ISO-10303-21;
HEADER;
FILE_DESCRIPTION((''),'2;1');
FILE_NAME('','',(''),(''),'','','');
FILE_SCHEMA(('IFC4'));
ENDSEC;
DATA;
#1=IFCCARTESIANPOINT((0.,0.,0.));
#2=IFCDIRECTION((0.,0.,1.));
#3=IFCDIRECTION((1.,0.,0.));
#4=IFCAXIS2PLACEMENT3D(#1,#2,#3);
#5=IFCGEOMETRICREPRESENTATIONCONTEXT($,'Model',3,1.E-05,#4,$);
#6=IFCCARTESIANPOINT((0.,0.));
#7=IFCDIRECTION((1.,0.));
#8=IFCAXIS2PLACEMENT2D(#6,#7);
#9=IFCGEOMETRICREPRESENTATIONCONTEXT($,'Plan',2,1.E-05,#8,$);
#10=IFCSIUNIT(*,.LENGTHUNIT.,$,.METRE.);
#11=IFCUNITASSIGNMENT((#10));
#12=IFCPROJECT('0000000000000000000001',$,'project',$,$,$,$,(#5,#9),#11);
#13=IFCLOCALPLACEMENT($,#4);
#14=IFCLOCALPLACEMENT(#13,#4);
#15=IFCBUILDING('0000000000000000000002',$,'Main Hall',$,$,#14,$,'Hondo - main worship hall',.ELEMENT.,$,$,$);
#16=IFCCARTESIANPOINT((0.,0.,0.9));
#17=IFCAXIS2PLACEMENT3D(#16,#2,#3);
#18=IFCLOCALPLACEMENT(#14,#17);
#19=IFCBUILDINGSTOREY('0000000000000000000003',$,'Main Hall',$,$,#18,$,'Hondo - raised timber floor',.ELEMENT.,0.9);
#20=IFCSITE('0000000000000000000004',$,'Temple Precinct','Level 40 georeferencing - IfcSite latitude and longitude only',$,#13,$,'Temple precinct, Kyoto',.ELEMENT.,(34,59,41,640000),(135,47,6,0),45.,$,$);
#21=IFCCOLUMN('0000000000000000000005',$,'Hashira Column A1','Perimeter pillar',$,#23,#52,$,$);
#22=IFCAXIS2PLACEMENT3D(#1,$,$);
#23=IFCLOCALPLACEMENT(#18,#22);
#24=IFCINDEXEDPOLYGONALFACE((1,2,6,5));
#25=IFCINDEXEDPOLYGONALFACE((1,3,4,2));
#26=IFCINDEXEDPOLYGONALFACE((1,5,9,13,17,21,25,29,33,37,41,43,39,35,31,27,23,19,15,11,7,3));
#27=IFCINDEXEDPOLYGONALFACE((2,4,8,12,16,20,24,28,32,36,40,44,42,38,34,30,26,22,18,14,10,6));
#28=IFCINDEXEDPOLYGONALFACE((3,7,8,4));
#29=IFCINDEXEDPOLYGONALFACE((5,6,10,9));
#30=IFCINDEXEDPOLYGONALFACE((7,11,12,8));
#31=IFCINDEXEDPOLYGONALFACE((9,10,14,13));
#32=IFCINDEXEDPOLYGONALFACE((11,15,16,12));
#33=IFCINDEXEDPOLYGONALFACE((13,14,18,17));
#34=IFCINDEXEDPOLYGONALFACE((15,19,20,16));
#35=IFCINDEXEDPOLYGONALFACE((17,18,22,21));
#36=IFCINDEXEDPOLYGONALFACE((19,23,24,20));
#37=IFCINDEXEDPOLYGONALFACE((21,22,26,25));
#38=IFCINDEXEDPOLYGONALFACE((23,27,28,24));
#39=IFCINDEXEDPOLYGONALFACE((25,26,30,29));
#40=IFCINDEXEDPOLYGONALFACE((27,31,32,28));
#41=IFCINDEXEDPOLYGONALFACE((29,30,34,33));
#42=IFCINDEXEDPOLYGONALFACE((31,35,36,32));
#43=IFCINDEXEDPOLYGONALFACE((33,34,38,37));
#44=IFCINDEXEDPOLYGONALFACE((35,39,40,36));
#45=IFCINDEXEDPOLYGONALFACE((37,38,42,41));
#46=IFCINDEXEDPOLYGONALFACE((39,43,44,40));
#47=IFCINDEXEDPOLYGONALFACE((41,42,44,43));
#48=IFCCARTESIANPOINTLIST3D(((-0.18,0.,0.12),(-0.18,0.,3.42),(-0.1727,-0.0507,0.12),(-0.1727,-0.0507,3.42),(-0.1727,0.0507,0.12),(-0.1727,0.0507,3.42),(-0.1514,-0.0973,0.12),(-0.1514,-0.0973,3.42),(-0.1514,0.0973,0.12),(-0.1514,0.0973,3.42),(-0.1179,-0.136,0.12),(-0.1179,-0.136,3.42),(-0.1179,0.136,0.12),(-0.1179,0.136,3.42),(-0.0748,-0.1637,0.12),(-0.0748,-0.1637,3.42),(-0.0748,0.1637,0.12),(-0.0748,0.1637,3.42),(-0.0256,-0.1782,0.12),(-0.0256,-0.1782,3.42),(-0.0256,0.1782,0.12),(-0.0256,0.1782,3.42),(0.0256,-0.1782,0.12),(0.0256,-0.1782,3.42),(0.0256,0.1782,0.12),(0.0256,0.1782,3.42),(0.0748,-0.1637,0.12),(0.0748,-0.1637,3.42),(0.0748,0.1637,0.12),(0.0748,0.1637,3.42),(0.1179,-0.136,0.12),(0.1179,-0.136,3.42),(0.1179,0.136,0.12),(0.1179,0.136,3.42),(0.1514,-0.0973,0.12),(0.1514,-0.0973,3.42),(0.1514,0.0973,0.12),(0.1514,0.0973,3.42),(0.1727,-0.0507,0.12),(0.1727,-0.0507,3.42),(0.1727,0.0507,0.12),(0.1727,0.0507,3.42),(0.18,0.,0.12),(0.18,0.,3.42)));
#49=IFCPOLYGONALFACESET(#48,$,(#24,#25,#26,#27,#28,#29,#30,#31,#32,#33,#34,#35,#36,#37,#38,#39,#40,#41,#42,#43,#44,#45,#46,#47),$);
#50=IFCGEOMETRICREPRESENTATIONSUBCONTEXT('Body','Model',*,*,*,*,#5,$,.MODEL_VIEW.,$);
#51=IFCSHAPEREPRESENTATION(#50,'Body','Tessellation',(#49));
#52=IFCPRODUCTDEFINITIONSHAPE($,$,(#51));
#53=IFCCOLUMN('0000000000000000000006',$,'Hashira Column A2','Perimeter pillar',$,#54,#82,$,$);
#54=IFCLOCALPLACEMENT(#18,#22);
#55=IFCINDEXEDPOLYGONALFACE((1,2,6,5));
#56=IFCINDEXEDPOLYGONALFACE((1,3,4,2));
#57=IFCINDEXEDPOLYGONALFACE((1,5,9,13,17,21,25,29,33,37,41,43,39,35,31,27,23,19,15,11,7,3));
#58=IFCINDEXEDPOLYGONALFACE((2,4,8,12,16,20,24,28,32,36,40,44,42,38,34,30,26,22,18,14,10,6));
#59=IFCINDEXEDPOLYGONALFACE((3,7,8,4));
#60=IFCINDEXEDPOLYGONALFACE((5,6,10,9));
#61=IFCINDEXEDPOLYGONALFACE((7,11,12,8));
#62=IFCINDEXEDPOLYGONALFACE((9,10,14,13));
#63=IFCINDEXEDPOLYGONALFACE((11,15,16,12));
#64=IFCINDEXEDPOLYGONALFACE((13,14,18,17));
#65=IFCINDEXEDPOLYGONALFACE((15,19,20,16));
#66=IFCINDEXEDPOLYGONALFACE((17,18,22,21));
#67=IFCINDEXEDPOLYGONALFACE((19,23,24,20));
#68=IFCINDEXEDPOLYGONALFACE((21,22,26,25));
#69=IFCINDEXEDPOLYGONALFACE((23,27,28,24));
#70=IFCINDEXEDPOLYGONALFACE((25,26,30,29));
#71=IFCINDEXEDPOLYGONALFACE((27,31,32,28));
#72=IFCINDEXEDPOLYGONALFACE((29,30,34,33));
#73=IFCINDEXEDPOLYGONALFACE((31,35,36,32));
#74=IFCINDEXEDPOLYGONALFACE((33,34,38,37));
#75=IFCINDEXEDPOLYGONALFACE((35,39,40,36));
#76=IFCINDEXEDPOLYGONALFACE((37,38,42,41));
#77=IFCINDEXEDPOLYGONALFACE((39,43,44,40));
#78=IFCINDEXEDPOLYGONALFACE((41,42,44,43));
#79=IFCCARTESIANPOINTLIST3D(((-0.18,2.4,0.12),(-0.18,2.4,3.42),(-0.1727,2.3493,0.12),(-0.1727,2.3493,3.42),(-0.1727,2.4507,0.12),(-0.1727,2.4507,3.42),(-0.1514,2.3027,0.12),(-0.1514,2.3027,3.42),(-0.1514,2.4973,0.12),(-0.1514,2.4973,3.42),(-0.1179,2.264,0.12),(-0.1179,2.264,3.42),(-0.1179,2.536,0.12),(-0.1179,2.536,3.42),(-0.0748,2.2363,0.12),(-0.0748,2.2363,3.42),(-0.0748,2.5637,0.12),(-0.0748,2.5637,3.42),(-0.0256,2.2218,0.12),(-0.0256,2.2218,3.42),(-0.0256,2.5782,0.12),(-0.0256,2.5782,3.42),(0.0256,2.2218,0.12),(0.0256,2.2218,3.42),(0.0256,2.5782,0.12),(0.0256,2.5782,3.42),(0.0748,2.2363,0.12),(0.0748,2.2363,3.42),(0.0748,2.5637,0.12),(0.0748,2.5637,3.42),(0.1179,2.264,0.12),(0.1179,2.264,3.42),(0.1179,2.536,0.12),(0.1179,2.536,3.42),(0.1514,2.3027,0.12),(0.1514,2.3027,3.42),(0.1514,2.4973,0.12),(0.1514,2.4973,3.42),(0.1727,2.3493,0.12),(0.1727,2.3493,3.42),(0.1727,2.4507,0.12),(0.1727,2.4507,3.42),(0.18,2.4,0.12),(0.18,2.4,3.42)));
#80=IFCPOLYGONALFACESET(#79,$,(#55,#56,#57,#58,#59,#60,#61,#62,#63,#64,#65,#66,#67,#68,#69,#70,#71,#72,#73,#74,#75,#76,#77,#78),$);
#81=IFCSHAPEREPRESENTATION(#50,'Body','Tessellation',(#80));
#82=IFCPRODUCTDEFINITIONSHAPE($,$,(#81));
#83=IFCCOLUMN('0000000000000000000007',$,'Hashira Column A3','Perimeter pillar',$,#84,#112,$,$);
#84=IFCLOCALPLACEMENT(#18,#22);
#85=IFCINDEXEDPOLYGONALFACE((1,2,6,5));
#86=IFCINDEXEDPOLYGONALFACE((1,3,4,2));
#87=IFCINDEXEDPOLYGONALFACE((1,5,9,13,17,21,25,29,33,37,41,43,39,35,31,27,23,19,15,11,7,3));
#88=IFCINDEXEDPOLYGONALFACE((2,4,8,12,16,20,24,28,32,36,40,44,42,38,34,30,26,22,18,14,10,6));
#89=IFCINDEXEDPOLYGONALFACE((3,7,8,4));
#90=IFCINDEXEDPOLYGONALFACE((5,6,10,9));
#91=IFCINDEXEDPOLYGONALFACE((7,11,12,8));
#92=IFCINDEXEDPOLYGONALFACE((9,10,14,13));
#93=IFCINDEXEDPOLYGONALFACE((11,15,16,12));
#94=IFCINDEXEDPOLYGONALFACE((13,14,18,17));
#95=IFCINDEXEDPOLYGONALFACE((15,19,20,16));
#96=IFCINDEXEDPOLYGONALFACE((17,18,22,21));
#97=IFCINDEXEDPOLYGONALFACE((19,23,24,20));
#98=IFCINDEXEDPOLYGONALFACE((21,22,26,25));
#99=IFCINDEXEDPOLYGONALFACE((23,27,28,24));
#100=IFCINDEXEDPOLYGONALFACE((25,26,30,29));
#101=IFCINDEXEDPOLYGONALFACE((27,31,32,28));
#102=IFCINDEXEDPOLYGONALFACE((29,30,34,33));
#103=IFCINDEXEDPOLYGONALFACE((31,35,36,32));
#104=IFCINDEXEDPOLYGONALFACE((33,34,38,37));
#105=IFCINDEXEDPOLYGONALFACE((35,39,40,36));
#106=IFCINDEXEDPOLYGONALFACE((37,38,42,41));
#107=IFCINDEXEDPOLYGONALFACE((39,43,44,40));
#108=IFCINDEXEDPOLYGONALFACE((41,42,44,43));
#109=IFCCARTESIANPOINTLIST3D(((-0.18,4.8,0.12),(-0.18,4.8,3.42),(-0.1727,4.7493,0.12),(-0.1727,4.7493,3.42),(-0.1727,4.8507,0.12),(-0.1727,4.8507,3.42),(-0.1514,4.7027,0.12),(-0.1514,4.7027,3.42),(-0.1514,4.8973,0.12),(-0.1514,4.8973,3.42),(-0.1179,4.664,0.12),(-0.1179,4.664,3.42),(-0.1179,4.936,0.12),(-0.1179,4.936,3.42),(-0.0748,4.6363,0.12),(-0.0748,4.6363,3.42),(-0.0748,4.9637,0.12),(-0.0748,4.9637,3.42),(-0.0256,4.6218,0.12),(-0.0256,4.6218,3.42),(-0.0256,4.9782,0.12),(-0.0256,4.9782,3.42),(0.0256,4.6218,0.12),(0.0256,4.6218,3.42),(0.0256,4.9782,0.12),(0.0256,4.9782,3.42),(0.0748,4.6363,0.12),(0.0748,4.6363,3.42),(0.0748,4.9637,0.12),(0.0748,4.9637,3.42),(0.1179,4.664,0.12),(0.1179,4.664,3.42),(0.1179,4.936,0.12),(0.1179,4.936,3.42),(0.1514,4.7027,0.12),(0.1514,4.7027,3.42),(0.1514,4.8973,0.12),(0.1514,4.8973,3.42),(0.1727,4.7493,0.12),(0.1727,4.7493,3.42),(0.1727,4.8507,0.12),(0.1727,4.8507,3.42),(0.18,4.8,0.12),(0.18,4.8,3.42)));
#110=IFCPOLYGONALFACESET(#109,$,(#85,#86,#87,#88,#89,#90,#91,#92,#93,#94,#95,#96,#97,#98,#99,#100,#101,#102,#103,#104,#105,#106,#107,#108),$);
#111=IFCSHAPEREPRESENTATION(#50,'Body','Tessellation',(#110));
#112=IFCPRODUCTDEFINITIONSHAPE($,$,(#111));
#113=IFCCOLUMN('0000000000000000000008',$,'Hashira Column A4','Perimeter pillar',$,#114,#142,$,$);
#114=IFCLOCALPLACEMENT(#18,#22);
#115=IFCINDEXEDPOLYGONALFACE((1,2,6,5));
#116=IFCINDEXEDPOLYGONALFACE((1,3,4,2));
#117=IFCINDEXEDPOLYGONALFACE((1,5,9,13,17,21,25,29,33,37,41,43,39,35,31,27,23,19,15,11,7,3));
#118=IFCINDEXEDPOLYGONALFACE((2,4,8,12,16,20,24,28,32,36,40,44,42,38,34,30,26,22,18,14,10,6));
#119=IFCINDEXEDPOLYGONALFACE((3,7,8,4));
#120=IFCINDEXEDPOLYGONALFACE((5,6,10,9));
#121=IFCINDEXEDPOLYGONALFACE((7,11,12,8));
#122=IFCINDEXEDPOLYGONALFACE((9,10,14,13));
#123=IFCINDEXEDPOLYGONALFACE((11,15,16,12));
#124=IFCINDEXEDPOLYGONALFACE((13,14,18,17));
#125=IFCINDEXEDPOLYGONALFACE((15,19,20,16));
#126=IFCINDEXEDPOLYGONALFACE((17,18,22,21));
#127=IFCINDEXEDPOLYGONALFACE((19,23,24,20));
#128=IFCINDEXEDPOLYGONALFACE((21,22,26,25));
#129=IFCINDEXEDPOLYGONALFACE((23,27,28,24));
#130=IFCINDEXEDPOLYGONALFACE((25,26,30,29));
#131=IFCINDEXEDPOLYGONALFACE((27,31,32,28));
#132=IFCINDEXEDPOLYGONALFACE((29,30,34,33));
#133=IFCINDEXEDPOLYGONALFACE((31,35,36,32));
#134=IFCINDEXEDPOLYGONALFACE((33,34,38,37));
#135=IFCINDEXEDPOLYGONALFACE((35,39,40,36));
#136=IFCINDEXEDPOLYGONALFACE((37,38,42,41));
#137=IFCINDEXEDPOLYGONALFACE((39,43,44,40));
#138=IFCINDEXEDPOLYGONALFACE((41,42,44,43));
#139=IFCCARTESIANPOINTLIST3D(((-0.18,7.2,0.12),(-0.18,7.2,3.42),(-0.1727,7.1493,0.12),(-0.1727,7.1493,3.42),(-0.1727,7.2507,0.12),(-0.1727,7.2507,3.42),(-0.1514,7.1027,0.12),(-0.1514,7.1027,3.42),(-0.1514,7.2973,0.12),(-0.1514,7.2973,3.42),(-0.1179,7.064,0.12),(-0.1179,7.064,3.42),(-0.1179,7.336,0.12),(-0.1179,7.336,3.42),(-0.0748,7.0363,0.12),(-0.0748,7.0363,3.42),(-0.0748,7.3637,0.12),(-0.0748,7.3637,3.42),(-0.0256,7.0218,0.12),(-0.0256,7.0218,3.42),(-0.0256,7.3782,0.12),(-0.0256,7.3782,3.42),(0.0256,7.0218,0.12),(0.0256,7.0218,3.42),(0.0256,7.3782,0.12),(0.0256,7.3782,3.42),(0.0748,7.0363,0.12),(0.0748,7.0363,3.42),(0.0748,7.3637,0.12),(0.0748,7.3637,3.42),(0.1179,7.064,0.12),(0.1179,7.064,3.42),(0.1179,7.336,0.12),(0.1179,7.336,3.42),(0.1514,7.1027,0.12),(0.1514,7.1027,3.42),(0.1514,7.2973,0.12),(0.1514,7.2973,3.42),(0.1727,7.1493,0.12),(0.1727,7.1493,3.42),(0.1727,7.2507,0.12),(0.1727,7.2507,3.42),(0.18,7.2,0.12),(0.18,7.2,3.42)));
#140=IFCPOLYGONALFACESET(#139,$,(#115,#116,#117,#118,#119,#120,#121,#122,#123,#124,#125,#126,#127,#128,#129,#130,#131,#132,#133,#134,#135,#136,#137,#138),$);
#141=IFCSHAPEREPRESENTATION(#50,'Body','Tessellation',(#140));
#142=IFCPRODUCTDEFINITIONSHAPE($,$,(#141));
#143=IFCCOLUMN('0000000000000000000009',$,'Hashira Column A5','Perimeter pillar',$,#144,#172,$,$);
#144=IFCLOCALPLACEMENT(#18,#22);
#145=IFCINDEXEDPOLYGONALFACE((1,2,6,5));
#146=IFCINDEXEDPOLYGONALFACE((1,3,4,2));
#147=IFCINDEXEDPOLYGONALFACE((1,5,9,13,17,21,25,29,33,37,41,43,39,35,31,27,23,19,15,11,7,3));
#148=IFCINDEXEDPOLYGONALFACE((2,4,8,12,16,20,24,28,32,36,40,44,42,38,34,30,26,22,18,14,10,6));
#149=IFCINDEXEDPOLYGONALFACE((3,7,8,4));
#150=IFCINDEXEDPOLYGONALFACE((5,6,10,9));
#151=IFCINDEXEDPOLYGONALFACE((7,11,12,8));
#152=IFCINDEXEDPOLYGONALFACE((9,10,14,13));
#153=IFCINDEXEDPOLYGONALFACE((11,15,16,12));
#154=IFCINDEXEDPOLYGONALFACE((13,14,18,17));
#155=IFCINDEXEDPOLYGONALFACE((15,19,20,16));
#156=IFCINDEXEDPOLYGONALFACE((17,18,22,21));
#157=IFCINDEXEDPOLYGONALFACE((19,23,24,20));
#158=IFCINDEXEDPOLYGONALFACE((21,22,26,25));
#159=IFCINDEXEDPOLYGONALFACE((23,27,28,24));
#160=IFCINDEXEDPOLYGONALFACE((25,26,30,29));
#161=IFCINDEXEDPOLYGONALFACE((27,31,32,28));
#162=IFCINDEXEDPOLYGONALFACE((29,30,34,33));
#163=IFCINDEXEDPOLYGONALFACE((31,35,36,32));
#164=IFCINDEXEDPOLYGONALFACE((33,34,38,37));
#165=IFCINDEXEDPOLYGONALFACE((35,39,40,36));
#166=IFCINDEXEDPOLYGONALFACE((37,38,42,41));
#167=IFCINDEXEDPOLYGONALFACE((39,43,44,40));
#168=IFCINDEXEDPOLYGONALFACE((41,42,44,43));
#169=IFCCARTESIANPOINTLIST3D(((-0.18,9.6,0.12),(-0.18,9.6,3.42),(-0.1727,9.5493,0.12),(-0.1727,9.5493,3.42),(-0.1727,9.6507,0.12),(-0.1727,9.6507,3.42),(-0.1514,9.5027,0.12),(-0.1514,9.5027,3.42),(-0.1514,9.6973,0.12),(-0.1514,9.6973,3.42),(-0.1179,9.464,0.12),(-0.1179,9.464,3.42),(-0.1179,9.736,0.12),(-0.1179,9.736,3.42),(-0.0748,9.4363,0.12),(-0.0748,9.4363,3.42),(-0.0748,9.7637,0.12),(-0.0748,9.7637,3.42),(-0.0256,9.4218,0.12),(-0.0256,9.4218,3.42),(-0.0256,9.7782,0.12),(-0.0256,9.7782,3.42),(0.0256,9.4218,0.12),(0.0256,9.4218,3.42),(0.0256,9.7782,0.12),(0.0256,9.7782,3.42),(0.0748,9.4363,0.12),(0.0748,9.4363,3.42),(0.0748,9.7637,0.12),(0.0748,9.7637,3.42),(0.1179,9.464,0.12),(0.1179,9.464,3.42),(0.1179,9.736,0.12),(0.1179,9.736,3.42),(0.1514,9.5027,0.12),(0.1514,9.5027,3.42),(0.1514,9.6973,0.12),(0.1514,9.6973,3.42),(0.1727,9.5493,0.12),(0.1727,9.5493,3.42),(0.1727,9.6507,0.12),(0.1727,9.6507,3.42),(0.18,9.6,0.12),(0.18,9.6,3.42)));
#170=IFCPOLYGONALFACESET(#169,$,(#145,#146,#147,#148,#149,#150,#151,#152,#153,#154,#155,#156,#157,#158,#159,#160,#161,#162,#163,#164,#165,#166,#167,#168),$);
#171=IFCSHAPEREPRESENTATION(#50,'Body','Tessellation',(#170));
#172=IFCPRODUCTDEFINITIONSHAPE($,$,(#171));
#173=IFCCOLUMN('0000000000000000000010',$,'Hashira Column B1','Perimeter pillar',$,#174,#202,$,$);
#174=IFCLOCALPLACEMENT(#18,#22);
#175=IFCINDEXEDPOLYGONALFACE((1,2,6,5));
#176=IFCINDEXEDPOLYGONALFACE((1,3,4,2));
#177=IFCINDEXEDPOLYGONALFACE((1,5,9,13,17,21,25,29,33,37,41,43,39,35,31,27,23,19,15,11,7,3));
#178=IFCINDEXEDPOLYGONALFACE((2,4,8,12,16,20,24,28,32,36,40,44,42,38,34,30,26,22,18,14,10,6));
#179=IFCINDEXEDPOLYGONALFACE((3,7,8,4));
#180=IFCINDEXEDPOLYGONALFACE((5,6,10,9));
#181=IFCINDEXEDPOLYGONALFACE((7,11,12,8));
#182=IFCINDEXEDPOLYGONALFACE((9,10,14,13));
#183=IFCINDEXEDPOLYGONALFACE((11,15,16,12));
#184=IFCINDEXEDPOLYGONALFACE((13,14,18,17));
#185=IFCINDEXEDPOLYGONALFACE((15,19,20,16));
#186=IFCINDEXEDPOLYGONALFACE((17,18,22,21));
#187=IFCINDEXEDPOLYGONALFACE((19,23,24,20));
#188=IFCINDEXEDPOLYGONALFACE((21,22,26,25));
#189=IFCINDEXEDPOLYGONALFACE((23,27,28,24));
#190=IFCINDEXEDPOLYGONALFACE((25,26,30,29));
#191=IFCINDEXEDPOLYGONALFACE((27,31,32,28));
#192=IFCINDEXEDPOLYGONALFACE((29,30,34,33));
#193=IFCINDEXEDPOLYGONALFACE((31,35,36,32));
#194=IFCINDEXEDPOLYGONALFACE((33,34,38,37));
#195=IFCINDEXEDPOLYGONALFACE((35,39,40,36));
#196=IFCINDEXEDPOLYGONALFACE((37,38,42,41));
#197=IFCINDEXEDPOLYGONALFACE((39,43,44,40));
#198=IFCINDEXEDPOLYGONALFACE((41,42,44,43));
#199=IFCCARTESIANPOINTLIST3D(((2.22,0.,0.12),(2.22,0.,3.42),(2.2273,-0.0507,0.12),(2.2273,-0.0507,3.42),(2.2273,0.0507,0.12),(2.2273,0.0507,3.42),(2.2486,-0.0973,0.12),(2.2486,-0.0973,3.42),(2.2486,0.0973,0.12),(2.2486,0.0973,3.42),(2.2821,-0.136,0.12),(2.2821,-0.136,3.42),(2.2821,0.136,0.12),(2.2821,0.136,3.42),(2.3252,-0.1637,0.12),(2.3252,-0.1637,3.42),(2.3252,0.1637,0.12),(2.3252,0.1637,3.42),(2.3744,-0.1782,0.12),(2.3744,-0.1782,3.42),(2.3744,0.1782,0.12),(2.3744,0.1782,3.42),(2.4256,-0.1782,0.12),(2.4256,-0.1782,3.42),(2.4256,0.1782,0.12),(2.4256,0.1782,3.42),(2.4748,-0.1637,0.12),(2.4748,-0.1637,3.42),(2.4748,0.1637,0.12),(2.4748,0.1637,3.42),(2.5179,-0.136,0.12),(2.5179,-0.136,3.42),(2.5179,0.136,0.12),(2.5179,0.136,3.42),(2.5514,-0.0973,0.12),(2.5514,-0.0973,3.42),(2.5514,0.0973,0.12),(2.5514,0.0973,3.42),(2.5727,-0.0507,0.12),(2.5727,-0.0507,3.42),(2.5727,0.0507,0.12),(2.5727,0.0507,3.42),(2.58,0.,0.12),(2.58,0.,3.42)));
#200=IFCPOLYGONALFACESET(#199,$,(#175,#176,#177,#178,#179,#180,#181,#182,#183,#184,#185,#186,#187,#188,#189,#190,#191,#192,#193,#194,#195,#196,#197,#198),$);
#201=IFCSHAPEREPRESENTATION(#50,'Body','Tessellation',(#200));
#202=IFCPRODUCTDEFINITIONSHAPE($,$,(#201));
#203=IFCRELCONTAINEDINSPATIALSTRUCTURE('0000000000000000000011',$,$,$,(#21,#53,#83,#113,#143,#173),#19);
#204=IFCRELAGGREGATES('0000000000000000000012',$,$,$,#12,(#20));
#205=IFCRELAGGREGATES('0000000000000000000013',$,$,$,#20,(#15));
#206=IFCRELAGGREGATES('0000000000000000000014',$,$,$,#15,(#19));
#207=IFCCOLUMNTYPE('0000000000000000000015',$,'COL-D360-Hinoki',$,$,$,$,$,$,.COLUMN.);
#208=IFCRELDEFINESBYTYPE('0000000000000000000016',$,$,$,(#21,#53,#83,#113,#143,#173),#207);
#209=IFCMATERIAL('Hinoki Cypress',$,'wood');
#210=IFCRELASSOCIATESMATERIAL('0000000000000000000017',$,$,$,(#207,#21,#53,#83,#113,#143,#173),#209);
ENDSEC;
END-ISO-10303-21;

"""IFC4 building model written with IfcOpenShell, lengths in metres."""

from ifc_helpers import new_model, si_unit, frame, origin_with_axes, origin_2d_with_axis, place, context, subcontext, project, spatial, circle, extrude, material, material_profile, profile_set, profile_usage, type_object, element, save


model = new_model("IFC4")

# Units and contexts
model_context = context("Model", 3, precision=1e-05, world=origin_with_axes())
plan_context = context("Plan", 2, precision=1e-05, world=origin_2d_with_axis())
body_context = subcontext(model_context, "Body", "Model", "MODEL_VIEW")
ifc_project = project(units=[si_unit("LENGTHUNIT", "METRE")], contexts=[model_context, plan_context])

# Site, building, storey
site_placement = place(None, origin_with_axes())
site = spatial("IfcSite", under=ifc_project, at=site_placement, Name="Temple Precinct", Description="Level 40 georeferencing - IfcSite latitude and longitude only", LongName="Temple precinct, Kyoto", CompositionType="ELEMENT", RefLatitude=(34, 59, 41, 640000), RefLongitude=(135, 47, 6, 0), RefElevation=45.0)
building_placement = place(site_placement, origin_with_axes())
building = spatial("IfcBuilding", under=site, at=building_placement, Name="Main Hall", LongName="Hondo - main worship hall", CompositionType="ELEMENT")
storey_placement = place(building_placement, frame((0.0, 0.0, 0.9), z_axis=(0.0, 0.0, 1.0), x_axis=(1.0, 0.0, 0.0)))
storey = spatial("IfcBuildingStorey", under=building, at=storey_placement, Name="Main Hall", LongName="Hondo - raised timber floor", CompositionType="ELEMENT", Elevation=0.9)

# Columns
ifc_material_1 = material(Name="Hinoki Cypress", Category="wood")
ifc_material_profile = material_profile(ifc_material_1, circle(Radius=0.18))
ifc_profile_set = profile_set([ifc_material_profile], Name="COL-D360-Hinoki")
ifc_profile_usage_1 = profile_usage(ifc_profile_set)
column_type = type_object("IfcColumnType", Name="COL-D360-Hinoki", PredefinedType="COLUMN", material=ifc_profile_set)
column_1_placement = place(storey_placement, frame((0.0, 0.0, 0.12), z_axis=(0.0, 0.0, 1.0), x_axis=(1.0, 0.0, 0.0)))
element("IfcColumn", 1, at=column_1_placement, inside=storey, type_object=column_type, material=ifc_profile_usage_1, Name="Hashira Column A1", Description="Perimeter pillar", context=body_context, shape_type="SweptSolid", body=[
    extrude(circle(Radius=0.18), origin_with_axes(), (0.0, 0.0, 1.0), 3.3),
])
ifc_profile_usage_2 = profile_usage(ifc_profile_set)
column_2_placement = place(storey_placement, frame((0.0, 2.4, 0.12), z_axis=(0.0, 0.0, 1.0), x_axis=(1.0, 0.0, 0.0)))
element("IfcColumn", 2, at=column_2_placement, inside=storey, type_object=column_type, material=ifc_profile_usage_2, Name="Hashira Column A2", Description="Perimeter pillar", context=body_context, shape_type="SweptSolid", body=[
    extrude(circle(Radius=0.18), origin_with_axes(), (0.0, 0.0, 1.0), 3.3),
])
ifc_profile_usage_3 = profile_usage(ifc_profile_set)
column_3_placement = place(storey_placement, frame((0.0, 4.8, 0.12), z_axis=(0.0, 0.0, 1.0), x_axis=(1.0, 0.0, 0.0)))
element("IfcColumn", 3, at=column_3_placement, inside=storey, type_object=column_type, material=ifc_profile_usage_3, Name="Hashira Column A3", Description="Perimeter pillar", context=body_context, shape_type="SweptSolid", body=[
    extrude(circle(Radius=0.18), origin_with_axes(), (0.0, 0.0, 1.0), 3.3),
])
ifc_profile_usage_4 = profile_usage(ifc_profile_set)
column_4_placement = place(storey_placement, frame((0.0, 7.2, 0.12), z_axis=(0.0, 0.0, 1.0), x_axis=(1.0, 0.0, 0.0)))
element("IfcColumn", 4, at=column_4_placement, inside=storey, type_object=column_type, material=ifc_profile_usage_4, Name="Hashira Column A4", Description="Perimeter pillar", context=body_context, shape_type="SweptSolid", body=[
    extrude(circle(Radius=0.18), origin_with_axes(), (0.0, 0.0, 1.0), 3.3),
])
ifc_profile_usage_5 = profile_usage(ifc_profile_set)
column_5_placement = place(storey_placement, frame((0.0, 9.6, 0.12), z_axis=(0.0, 0.0, 1.0), x_axis=(1.0, 0.0, 0.0)))
element("IfcColumn", 5, at=column_5_placement, inside=storey, type_object=column_type, material=ifc_profile_usage_5, Name="Hashira Column A5", Description="Perimeter pillar", context=body_context, shape_type="SweptSolid", body=[
    extrude(circle(Radius=0.18), origin_with_axes(), (0.0, 0.0, 1.0), 3.3),
])
ifc_profile_usage_6 = profile_usage(ifc_profile_set)
column_6_placement = place(storey_placement, frame((2.4, 0.0, 0.12), z_axis=(0.0, 0.0, 1.0), x_axis=(1.0, 0.0, 0.0)))
element("IfcColumn", 6, at=column_6_placement, inside=storey, type_object=column_type, material=ifc_profile_usage_6, Name="Hashira Column B1", Description="Perimeter pillar", context=body_context, shape_type="SweptSolid", body=[
    extrude(circle(Radius=0.18), origin_with_axes(), (0.0, 0.0, 1.0), 3.3),
])

save(model, "model.ifc")
